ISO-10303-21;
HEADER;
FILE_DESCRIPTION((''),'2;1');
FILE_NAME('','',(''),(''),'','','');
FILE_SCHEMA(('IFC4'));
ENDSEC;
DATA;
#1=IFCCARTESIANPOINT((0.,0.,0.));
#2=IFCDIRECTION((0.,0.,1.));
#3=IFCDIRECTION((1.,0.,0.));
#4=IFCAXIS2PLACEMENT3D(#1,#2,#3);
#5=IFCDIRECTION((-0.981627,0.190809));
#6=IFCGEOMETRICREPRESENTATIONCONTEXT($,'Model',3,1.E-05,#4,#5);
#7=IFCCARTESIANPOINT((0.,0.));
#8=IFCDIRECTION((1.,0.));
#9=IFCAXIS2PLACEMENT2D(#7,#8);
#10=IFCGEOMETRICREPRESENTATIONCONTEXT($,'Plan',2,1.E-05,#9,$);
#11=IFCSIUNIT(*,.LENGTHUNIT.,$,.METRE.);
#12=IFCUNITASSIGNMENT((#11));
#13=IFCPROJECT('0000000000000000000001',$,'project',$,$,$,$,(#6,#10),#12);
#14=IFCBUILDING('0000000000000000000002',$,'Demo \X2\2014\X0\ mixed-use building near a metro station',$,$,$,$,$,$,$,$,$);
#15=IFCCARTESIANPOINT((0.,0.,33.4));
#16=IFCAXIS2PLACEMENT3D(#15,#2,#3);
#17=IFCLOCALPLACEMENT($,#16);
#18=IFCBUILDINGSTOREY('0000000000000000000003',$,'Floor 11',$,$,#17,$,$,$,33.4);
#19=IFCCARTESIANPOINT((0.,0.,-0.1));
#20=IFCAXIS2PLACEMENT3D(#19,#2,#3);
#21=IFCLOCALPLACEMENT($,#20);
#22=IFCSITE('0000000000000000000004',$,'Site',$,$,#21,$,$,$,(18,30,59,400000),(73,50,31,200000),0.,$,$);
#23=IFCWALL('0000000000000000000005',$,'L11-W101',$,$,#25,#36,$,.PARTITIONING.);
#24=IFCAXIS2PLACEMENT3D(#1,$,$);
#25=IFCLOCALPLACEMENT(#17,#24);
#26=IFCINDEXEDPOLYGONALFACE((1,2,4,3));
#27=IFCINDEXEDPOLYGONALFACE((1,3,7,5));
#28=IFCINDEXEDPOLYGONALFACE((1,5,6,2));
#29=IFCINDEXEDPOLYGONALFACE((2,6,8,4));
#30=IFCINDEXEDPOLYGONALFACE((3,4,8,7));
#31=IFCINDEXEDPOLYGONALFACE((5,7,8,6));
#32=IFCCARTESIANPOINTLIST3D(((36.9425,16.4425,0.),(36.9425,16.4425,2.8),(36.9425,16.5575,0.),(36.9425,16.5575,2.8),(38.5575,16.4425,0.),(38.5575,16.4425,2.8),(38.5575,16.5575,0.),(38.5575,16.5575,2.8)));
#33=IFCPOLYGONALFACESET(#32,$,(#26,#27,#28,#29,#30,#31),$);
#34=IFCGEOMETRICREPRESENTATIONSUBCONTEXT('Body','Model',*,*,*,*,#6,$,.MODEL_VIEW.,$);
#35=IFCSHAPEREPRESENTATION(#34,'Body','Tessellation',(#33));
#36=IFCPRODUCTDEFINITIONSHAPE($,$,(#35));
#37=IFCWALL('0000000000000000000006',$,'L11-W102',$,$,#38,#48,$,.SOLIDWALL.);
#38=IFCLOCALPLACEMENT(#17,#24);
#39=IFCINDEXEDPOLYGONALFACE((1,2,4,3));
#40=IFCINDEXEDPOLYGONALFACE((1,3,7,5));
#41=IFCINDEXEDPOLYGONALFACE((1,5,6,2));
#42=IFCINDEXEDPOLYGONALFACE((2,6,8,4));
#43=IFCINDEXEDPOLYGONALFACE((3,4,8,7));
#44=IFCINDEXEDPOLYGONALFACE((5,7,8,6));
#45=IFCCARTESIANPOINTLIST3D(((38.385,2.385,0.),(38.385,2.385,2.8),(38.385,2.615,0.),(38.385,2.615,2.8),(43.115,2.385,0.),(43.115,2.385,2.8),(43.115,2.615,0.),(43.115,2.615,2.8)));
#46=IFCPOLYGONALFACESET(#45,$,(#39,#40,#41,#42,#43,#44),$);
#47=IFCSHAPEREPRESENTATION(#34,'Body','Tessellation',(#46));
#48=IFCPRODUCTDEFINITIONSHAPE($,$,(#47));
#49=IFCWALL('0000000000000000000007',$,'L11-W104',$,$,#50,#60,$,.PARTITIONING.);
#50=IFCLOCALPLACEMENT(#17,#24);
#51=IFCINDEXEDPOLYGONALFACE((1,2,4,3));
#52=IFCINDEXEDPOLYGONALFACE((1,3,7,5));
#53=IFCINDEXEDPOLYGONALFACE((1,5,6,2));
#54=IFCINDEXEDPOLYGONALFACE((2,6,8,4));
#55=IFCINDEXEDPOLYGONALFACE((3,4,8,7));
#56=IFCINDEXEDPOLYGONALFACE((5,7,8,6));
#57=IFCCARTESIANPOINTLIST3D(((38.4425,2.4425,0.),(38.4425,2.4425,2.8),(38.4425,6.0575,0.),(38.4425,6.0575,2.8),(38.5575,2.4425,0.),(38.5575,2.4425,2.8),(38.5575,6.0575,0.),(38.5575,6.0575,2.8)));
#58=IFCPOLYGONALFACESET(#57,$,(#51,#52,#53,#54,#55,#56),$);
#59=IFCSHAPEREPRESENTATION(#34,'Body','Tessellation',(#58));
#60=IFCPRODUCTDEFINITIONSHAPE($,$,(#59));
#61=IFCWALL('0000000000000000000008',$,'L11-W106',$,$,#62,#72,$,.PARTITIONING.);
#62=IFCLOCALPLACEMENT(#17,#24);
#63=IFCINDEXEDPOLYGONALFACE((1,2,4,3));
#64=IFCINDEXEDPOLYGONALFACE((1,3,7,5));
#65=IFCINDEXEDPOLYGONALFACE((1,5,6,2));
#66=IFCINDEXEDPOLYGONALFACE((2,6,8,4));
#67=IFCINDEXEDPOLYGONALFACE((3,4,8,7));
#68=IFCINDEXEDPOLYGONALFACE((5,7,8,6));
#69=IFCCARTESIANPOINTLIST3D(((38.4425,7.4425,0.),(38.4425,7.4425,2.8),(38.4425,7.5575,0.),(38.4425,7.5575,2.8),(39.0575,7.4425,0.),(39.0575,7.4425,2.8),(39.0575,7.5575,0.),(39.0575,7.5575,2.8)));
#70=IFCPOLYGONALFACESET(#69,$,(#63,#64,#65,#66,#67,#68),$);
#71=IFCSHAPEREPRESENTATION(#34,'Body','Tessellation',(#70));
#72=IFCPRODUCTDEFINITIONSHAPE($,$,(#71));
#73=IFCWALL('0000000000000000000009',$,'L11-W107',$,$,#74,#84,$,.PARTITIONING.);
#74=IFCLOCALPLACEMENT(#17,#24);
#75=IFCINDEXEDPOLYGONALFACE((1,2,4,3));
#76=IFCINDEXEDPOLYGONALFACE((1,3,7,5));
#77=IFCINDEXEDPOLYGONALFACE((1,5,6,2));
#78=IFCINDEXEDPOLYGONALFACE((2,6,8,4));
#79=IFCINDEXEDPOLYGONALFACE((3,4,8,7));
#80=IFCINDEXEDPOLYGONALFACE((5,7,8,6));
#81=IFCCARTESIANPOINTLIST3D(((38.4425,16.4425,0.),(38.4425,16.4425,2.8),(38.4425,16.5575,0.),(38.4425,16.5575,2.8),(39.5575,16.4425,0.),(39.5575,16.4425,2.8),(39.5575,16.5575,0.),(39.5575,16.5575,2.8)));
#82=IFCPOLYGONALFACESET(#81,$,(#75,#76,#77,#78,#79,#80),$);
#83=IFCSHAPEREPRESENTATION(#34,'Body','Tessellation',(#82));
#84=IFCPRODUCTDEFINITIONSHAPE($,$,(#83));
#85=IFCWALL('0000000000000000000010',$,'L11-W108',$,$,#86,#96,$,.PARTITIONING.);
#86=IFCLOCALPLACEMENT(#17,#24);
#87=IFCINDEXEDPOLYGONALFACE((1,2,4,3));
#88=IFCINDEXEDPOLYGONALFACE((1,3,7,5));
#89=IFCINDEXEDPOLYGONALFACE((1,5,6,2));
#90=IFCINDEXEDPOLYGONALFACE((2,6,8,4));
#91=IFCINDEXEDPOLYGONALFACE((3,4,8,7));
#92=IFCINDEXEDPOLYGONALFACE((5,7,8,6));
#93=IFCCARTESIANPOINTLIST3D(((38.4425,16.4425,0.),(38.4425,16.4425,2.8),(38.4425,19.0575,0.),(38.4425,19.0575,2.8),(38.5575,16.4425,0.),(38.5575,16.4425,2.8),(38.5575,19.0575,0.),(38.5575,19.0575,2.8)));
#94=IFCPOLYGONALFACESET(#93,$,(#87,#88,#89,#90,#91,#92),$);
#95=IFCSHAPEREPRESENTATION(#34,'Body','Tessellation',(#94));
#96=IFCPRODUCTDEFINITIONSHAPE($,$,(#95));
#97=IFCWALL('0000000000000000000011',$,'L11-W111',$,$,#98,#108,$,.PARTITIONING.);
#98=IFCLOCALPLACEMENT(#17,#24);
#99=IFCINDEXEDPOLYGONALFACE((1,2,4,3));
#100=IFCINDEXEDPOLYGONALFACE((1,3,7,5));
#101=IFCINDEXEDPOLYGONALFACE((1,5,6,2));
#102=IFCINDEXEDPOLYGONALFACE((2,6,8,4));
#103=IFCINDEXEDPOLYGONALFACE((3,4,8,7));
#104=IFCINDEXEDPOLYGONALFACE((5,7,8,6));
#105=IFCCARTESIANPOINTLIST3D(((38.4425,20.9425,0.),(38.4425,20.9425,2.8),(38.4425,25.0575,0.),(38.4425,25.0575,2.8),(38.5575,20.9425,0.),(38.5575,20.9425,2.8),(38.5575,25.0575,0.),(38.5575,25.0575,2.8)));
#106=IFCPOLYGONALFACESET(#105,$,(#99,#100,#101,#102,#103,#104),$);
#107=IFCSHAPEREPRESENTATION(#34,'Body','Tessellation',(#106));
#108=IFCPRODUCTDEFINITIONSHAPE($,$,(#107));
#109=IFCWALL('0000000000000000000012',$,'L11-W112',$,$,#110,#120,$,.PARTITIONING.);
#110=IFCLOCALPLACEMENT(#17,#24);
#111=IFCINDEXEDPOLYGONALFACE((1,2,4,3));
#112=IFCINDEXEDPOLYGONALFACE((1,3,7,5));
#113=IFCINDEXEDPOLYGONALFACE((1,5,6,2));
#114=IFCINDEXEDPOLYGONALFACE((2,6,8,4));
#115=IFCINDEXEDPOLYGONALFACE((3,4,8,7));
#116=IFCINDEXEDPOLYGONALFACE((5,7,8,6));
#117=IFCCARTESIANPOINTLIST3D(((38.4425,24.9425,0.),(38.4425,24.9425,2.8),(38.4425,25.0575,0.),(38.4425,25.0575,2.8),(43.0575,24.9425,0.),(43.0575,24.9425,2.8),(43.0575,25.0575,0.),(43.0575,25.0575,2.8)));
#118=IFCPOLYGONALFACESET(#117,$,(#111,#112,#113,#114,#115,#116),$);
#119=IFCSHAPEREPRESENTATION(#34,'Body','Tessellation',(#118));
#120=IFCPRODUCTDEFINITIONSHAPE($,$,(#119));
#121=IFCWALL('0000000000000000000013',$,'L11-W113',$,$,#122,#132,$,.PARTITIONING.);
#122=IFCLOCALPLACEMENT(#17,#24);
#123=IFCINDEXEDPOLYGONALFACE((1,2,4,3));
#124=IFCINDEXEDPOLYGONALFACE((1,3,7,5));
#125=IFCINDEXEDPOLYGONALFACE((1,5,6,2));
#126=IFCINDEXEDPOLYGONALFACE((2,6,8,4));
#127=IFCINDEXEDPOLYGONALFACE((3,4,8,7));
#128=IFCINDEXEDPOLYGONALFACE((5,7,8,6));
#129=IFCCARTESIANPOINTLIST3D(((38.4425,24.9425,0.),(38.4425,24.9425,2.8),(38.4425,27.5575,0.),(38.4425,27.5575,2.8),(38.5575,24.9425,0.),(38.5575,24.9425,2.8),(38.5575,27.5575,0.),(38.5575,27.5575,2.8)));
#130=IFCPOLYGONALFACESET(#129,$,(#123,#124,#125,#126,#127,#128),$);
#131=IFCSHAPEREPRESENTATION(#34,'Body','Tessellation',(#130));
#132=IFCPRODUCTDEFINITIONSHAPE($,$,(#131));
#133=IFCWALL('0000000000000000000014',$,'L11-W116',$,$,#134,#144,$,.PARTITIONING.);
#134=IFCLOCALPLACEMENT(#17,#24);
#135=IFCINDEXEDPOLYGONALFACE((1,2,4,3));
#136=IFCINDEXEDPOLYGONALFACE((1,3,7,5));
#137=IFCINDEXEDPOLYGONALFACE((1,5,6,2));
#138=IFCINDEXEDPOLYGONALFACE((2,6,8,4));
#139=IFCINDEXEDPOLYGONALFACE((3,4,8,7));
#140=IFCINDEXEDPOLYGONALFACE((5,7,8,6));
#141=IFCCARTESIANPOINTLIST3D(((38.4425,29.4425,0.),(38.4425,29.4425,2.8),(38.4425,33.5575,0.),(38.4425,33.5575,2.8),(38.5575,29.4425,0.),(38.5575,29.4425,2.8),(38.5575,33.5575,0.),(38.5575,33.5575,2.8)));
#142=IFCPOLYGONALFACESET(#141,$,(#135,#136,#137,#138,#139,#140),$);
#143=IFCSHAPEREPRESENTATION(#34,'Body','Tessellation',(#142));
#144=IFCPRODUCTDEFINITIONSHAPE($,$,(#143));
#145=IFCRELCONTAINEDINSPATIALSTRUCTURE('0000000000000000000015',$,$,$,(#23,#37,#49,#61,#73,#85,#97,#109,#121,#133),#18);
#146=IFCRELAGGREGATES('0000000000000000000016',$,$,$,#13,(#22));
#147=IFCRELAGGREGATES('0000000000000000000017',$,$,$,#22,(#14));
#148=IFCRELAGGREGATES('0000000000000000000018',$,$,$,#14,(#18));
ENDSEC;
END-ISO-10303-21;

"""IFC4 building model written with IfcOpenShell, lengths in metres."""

from ifc_helpers import new_model, si_unit, direction, frame, origin_with_axes, origin_2d_with_axis, place, context, subcontext, project, spatial, line, indexed_curve, outline, extrude, element, save


model = new_model("IFC4")

# Units and contexts
model_context = context("Model", 3, precision=1e-05, world=origin_with_axes(), true_north=direction((-0.981627, 0.190809)))
plan_context = context("Plan", 2, precision=1e-05, world=origin_2d_with_axis())
body_context = subcontext(model_context, "Body", "Model", "MODEL_VIEW")
ifc_project = project(units=[si_unit("LENGTHUNIT", "METRE")], contexts=[model_context, plan_context])

# Site, building, storey
site_placement = place(None, frame((0.0, 0.0, -0.1), z_axis=(0.0, 0.0, 1.0), x_axis=(1.0, 0.0, 0.0)))
site = spatial("IfcSite", under=ifc_project, at=site_placement, Name="Site", RefLatitude=(18, 30, 59, 400000), RefLongitude=(73, 50, 31, 200000), RefElevation=0.0)
building = spatial("IfcBuilding", under=site, Name="Demo — mixed-use building near a metro station")
storey_placement = place(None, frame((0.0, 0.0, 33.4), z_axis=(0.0, 0.0, 1.0), x_axis=(1.0, 0.0, 0.0)))
storey = spatial("IfcBuildingStorey", under=building, at=storey_placement, Name="Floor 11", Elevation=33.4)

# Walls
wall_1_placement = place(storey_placement, frame((0.0, 0.0, -33.4), z_axis=(0.0, 0.0, 1.0), x_axis=(1.0, 0.0, 0.0)))
element("IfcWall", 1, at=wall_1_placement, inside=storey, Name="L11-W101", PredefinedType="PARTITIONING", context=body_context, shape_type="SweptSolid", body=[
    extrude(outline(indexed_curve([(38.5575, 16.4425), (36.9425, 16.4425), (36.9425, 16.5575), (38.5575, 16.5575)], segments=[line(1, 2, 3, 4, 1)])), frame((0.0, 0.0, 33.4), z_axis=(0.0, 0.0, 1.0), x_axis=(1.0, 0.0, 0.0)), (0.0, 0.0, 1.0), 2.8),
])
wall_2_placement = place(storey_placement, frame((0.0, 0.0, -33.4), z_axis=(0.0, 0.0, 1.0), x_axis=(1.0, 0.0, 0.0)))
element("IfcWall", 2, at=wall_2_placement, inside=storey, Name="L11-W102", PredefinedType="SOLIDWALL", context=body_context, shape_type="SweptSolid", body=[
    extrude(outline(indexed_curve([(38.385, 2.615), (43.115, 2.615), (43.115, 2.385), (38.385, 2.385)], segments=[line(1, 2, 3, 4, 1)])), frame((0.0, 0.0, 33.4), z_axis=(0.0, 0.0, 1.0), x_axis=(1.0, 0.0, 0.0)), (0.0, 0.0, 1.0), 2.8),
])

# Wall
wall_3_placement = place(storey_placement, frame((0.0, 0.0, -33.4), z_axis=(0.0, 0.0, 1.0), x_axis=(1.0, 0.0, 0.0)))
element("IfcWall", 3, at=wall_3_placement, inside=storey, Name="L11-W104", PredefinedType="PARTITIONING", context=body_context, shape_type="SweptSolid", body=[
    extrude(outline(indexed_curve([(38.5575, 6.0575), (38.5575, 2.4425), (38.4425, 2.4425), (38.4425, 6.0575)], segments=[line(1, 2, 3, 4, 1)])), frame((0.0, 0.0, 33.4), z_axis=(0.0, 0.0, 1.0), x_axis=(1.0, 0.0, 0.0)), (0.0, 0.0, 1.0), 2.8),
])

# Walls
wall_4_placement = place(storey_placement, frame((0.0, 0.0, -33.4), z_axis=(0.0, 0.0, 1.0), x_axis=(1.0, 0.0, 0.0)))
element("IfcWall", 4, at=wall_4_placement, inside=storey, Name="L11-W106", PredefinedType="PARTITIONING", context=body_context, shape_type="SweptSolid", body=[
    extrude(outline(indexed_curve([(39.0575, 7.4425), (38.4425, 7.4425), (38.4425, 7.5575), (39.0575, 7.5575)], segments=[line(1, 2, 3, 4, 1)])), frame((0.0, 0.0, 33.4), z_axis=(0.0, 0.0, 1.0), x_axis=(1.0, 0.0, 0.0)), (0.0, 0.0, 1.0), 2.8),
])
wall_5_placement = place(storey_placement, frame((0.0, 0.0, -33.4), z_axis=(0.0, 0.0, 1.0), x_axis=(1.0, 0.0, 0.0)))
element("IfcWall", 5, at=wall_5_placement, inside=storey, Name="L11-W107", PredefinedType="PARTITIONING", context=body_context, shape_type="SweptSolid", body=[
    extrude(outline(indexed_curve([(39.5575, 16.4425), (38.4425, 16.4425), (38.4425, 16.5575), (39.5575, 16.5575)], segments=[line(1, 2, 3, 4, 1)])), frame((0.0, 0.0, 33.4), z_axis=(0.0, 0.0, 1.0), x_axis=(1.0, 0.0, 0.0)), (0.0, 0.0, 1.0), 2.8),
])
wall_6_placement = place(storey_placement, frame((0.0, 0.0, -33.4), z_axis=(0.0, 0.0, 1.0), x_axis=(1.0, 0.0, 0.0)))
element("IfcWall", 6, at=wall_6_placement, inside=storey, Name="L11-W108", PredefinedType="PARTITIONING", context=body_context, shape_type="SweptSolid", body=[
    extrude(outline(indexed_curve([(38.5575, 19.0575), (38.5575, 16.4425), (38.4425, 16.4425), (38.4425, 19.0575)], segments=[line(1, 2, 3, 4, 1)])), frame((0.0, 0.0, 33.4), z_axis=(0.0, 0.0, 1.0), x_axis=(1.0, 0.0, 0.0)), (0.0, 0.0, 1.0), 2.8),
])

# Walls
wall_7_placement = place(storey_placement, frame((0.0, 0.0, -33.4), z_axis=(0.0, 0.0, 1.0), x_axis=(1.0, 0.0, 0.0)))
element("IfcWall", 7, at=wall_7_placement, inside=storey, Name="L11-W111", PredefinedType="PARTITIONING", context=body_context, shape_type="SweptSolid", body=[
    extrude(outline(indexed_curve([(38.5575, 25.0575), (38.5575, 20.9425), (38.4425, 20.9425), (38.4425, 25.0575)], segments=[line(1, 2, 3, 4, 1)])), frame((0.0, 0.0, 33.4), z_axis=(0.0, 0.0, 1.0), x_axis=(1.0, 0.0, 0.0)), (0.0, 0.0, 1.0), 2.8),
])
wall_8_placement = place(storey_placement, frame((0.0, 0.0, -33.4), z_axis=(0.0, 0.0, 1.0), x_axis=(1.0, 0.0, 0.0)))
element("IfcWall", 8, at=wall_8_placement, inside=storey, Name="L11-W112", PredefinedType="PARTITIONING", context=body_context, shape_type="SweptSolid", body=[
    extrude(outline(indexed_curve([(43.0575, 24.9425), (38.4425, 24.9425), (38.4425, 25.0575), (43.0575, 25.0575)], segments=[line(1, 2, 3, 4, 1)])), frame((0.0, 0.0, 33.4), z_axis=(0.0, 0.0, 1.0), x_axis=(1.0, 0.0, 0.0)), (0.0, 0.0, 1.0), 2.8),
])
wall_9_placement = place(storey_placement, frame((0.0, 0.0, -33.4), z_axis=(0.0, 0.0, 1.0), x_axis=(1.0, 0.0, 0.0)))
element("IfcWall", 9, at=wall_9_placement, inside=storey, Name="L11-W113", PredefinedType="PARTITIONING", context=body_context, shape_type="SweptSolid", body=[
    extrude(outline(indexed_curve([(38.5575, 27.5575), (38.5575, 24.9425), (38.4425, 24.9425), (38.4425, 27.5575)], segments=[line(1, 2, 3, 4, 1)])), frame((0.0, 0.0, 33.4), z_axis=(0.0, 0.0, 1.0), x_axis=(1.0, 0.0, 0.0)), (0.0, 0.0, 1.0), 2.8),
])

# Wall
wall_10_placement = place(storey_placement, frame((0.0, 0.0, -33.4), z_axis=(0.0, 0.0, 1.0), x_axis=(1.0, 0.0, 0.0)))
element("IfcWall", 10, at=wall_10_placement, inside=storey, Name="L11-W116", PredefinedType="PARTITIONING", context=body_context, shape_type="SweptSolid", body=[
    extrude(outline(indexed_curve([(38.5575, 33.5575), (38.5575, 29.4425), (38.4425, 29.4425), (38.4425, 33.5575)], segments=[line(1, 2, 3, 4, 1)])), frame((0.0, 0.0, 33.4), z_axis=(0.0, 0.0, 1.0), x_axis=(1.0, 0.0, 0.0)), (0.0, 0.0, 1.0), 2.8),
])

save(model, "model.ifc")
